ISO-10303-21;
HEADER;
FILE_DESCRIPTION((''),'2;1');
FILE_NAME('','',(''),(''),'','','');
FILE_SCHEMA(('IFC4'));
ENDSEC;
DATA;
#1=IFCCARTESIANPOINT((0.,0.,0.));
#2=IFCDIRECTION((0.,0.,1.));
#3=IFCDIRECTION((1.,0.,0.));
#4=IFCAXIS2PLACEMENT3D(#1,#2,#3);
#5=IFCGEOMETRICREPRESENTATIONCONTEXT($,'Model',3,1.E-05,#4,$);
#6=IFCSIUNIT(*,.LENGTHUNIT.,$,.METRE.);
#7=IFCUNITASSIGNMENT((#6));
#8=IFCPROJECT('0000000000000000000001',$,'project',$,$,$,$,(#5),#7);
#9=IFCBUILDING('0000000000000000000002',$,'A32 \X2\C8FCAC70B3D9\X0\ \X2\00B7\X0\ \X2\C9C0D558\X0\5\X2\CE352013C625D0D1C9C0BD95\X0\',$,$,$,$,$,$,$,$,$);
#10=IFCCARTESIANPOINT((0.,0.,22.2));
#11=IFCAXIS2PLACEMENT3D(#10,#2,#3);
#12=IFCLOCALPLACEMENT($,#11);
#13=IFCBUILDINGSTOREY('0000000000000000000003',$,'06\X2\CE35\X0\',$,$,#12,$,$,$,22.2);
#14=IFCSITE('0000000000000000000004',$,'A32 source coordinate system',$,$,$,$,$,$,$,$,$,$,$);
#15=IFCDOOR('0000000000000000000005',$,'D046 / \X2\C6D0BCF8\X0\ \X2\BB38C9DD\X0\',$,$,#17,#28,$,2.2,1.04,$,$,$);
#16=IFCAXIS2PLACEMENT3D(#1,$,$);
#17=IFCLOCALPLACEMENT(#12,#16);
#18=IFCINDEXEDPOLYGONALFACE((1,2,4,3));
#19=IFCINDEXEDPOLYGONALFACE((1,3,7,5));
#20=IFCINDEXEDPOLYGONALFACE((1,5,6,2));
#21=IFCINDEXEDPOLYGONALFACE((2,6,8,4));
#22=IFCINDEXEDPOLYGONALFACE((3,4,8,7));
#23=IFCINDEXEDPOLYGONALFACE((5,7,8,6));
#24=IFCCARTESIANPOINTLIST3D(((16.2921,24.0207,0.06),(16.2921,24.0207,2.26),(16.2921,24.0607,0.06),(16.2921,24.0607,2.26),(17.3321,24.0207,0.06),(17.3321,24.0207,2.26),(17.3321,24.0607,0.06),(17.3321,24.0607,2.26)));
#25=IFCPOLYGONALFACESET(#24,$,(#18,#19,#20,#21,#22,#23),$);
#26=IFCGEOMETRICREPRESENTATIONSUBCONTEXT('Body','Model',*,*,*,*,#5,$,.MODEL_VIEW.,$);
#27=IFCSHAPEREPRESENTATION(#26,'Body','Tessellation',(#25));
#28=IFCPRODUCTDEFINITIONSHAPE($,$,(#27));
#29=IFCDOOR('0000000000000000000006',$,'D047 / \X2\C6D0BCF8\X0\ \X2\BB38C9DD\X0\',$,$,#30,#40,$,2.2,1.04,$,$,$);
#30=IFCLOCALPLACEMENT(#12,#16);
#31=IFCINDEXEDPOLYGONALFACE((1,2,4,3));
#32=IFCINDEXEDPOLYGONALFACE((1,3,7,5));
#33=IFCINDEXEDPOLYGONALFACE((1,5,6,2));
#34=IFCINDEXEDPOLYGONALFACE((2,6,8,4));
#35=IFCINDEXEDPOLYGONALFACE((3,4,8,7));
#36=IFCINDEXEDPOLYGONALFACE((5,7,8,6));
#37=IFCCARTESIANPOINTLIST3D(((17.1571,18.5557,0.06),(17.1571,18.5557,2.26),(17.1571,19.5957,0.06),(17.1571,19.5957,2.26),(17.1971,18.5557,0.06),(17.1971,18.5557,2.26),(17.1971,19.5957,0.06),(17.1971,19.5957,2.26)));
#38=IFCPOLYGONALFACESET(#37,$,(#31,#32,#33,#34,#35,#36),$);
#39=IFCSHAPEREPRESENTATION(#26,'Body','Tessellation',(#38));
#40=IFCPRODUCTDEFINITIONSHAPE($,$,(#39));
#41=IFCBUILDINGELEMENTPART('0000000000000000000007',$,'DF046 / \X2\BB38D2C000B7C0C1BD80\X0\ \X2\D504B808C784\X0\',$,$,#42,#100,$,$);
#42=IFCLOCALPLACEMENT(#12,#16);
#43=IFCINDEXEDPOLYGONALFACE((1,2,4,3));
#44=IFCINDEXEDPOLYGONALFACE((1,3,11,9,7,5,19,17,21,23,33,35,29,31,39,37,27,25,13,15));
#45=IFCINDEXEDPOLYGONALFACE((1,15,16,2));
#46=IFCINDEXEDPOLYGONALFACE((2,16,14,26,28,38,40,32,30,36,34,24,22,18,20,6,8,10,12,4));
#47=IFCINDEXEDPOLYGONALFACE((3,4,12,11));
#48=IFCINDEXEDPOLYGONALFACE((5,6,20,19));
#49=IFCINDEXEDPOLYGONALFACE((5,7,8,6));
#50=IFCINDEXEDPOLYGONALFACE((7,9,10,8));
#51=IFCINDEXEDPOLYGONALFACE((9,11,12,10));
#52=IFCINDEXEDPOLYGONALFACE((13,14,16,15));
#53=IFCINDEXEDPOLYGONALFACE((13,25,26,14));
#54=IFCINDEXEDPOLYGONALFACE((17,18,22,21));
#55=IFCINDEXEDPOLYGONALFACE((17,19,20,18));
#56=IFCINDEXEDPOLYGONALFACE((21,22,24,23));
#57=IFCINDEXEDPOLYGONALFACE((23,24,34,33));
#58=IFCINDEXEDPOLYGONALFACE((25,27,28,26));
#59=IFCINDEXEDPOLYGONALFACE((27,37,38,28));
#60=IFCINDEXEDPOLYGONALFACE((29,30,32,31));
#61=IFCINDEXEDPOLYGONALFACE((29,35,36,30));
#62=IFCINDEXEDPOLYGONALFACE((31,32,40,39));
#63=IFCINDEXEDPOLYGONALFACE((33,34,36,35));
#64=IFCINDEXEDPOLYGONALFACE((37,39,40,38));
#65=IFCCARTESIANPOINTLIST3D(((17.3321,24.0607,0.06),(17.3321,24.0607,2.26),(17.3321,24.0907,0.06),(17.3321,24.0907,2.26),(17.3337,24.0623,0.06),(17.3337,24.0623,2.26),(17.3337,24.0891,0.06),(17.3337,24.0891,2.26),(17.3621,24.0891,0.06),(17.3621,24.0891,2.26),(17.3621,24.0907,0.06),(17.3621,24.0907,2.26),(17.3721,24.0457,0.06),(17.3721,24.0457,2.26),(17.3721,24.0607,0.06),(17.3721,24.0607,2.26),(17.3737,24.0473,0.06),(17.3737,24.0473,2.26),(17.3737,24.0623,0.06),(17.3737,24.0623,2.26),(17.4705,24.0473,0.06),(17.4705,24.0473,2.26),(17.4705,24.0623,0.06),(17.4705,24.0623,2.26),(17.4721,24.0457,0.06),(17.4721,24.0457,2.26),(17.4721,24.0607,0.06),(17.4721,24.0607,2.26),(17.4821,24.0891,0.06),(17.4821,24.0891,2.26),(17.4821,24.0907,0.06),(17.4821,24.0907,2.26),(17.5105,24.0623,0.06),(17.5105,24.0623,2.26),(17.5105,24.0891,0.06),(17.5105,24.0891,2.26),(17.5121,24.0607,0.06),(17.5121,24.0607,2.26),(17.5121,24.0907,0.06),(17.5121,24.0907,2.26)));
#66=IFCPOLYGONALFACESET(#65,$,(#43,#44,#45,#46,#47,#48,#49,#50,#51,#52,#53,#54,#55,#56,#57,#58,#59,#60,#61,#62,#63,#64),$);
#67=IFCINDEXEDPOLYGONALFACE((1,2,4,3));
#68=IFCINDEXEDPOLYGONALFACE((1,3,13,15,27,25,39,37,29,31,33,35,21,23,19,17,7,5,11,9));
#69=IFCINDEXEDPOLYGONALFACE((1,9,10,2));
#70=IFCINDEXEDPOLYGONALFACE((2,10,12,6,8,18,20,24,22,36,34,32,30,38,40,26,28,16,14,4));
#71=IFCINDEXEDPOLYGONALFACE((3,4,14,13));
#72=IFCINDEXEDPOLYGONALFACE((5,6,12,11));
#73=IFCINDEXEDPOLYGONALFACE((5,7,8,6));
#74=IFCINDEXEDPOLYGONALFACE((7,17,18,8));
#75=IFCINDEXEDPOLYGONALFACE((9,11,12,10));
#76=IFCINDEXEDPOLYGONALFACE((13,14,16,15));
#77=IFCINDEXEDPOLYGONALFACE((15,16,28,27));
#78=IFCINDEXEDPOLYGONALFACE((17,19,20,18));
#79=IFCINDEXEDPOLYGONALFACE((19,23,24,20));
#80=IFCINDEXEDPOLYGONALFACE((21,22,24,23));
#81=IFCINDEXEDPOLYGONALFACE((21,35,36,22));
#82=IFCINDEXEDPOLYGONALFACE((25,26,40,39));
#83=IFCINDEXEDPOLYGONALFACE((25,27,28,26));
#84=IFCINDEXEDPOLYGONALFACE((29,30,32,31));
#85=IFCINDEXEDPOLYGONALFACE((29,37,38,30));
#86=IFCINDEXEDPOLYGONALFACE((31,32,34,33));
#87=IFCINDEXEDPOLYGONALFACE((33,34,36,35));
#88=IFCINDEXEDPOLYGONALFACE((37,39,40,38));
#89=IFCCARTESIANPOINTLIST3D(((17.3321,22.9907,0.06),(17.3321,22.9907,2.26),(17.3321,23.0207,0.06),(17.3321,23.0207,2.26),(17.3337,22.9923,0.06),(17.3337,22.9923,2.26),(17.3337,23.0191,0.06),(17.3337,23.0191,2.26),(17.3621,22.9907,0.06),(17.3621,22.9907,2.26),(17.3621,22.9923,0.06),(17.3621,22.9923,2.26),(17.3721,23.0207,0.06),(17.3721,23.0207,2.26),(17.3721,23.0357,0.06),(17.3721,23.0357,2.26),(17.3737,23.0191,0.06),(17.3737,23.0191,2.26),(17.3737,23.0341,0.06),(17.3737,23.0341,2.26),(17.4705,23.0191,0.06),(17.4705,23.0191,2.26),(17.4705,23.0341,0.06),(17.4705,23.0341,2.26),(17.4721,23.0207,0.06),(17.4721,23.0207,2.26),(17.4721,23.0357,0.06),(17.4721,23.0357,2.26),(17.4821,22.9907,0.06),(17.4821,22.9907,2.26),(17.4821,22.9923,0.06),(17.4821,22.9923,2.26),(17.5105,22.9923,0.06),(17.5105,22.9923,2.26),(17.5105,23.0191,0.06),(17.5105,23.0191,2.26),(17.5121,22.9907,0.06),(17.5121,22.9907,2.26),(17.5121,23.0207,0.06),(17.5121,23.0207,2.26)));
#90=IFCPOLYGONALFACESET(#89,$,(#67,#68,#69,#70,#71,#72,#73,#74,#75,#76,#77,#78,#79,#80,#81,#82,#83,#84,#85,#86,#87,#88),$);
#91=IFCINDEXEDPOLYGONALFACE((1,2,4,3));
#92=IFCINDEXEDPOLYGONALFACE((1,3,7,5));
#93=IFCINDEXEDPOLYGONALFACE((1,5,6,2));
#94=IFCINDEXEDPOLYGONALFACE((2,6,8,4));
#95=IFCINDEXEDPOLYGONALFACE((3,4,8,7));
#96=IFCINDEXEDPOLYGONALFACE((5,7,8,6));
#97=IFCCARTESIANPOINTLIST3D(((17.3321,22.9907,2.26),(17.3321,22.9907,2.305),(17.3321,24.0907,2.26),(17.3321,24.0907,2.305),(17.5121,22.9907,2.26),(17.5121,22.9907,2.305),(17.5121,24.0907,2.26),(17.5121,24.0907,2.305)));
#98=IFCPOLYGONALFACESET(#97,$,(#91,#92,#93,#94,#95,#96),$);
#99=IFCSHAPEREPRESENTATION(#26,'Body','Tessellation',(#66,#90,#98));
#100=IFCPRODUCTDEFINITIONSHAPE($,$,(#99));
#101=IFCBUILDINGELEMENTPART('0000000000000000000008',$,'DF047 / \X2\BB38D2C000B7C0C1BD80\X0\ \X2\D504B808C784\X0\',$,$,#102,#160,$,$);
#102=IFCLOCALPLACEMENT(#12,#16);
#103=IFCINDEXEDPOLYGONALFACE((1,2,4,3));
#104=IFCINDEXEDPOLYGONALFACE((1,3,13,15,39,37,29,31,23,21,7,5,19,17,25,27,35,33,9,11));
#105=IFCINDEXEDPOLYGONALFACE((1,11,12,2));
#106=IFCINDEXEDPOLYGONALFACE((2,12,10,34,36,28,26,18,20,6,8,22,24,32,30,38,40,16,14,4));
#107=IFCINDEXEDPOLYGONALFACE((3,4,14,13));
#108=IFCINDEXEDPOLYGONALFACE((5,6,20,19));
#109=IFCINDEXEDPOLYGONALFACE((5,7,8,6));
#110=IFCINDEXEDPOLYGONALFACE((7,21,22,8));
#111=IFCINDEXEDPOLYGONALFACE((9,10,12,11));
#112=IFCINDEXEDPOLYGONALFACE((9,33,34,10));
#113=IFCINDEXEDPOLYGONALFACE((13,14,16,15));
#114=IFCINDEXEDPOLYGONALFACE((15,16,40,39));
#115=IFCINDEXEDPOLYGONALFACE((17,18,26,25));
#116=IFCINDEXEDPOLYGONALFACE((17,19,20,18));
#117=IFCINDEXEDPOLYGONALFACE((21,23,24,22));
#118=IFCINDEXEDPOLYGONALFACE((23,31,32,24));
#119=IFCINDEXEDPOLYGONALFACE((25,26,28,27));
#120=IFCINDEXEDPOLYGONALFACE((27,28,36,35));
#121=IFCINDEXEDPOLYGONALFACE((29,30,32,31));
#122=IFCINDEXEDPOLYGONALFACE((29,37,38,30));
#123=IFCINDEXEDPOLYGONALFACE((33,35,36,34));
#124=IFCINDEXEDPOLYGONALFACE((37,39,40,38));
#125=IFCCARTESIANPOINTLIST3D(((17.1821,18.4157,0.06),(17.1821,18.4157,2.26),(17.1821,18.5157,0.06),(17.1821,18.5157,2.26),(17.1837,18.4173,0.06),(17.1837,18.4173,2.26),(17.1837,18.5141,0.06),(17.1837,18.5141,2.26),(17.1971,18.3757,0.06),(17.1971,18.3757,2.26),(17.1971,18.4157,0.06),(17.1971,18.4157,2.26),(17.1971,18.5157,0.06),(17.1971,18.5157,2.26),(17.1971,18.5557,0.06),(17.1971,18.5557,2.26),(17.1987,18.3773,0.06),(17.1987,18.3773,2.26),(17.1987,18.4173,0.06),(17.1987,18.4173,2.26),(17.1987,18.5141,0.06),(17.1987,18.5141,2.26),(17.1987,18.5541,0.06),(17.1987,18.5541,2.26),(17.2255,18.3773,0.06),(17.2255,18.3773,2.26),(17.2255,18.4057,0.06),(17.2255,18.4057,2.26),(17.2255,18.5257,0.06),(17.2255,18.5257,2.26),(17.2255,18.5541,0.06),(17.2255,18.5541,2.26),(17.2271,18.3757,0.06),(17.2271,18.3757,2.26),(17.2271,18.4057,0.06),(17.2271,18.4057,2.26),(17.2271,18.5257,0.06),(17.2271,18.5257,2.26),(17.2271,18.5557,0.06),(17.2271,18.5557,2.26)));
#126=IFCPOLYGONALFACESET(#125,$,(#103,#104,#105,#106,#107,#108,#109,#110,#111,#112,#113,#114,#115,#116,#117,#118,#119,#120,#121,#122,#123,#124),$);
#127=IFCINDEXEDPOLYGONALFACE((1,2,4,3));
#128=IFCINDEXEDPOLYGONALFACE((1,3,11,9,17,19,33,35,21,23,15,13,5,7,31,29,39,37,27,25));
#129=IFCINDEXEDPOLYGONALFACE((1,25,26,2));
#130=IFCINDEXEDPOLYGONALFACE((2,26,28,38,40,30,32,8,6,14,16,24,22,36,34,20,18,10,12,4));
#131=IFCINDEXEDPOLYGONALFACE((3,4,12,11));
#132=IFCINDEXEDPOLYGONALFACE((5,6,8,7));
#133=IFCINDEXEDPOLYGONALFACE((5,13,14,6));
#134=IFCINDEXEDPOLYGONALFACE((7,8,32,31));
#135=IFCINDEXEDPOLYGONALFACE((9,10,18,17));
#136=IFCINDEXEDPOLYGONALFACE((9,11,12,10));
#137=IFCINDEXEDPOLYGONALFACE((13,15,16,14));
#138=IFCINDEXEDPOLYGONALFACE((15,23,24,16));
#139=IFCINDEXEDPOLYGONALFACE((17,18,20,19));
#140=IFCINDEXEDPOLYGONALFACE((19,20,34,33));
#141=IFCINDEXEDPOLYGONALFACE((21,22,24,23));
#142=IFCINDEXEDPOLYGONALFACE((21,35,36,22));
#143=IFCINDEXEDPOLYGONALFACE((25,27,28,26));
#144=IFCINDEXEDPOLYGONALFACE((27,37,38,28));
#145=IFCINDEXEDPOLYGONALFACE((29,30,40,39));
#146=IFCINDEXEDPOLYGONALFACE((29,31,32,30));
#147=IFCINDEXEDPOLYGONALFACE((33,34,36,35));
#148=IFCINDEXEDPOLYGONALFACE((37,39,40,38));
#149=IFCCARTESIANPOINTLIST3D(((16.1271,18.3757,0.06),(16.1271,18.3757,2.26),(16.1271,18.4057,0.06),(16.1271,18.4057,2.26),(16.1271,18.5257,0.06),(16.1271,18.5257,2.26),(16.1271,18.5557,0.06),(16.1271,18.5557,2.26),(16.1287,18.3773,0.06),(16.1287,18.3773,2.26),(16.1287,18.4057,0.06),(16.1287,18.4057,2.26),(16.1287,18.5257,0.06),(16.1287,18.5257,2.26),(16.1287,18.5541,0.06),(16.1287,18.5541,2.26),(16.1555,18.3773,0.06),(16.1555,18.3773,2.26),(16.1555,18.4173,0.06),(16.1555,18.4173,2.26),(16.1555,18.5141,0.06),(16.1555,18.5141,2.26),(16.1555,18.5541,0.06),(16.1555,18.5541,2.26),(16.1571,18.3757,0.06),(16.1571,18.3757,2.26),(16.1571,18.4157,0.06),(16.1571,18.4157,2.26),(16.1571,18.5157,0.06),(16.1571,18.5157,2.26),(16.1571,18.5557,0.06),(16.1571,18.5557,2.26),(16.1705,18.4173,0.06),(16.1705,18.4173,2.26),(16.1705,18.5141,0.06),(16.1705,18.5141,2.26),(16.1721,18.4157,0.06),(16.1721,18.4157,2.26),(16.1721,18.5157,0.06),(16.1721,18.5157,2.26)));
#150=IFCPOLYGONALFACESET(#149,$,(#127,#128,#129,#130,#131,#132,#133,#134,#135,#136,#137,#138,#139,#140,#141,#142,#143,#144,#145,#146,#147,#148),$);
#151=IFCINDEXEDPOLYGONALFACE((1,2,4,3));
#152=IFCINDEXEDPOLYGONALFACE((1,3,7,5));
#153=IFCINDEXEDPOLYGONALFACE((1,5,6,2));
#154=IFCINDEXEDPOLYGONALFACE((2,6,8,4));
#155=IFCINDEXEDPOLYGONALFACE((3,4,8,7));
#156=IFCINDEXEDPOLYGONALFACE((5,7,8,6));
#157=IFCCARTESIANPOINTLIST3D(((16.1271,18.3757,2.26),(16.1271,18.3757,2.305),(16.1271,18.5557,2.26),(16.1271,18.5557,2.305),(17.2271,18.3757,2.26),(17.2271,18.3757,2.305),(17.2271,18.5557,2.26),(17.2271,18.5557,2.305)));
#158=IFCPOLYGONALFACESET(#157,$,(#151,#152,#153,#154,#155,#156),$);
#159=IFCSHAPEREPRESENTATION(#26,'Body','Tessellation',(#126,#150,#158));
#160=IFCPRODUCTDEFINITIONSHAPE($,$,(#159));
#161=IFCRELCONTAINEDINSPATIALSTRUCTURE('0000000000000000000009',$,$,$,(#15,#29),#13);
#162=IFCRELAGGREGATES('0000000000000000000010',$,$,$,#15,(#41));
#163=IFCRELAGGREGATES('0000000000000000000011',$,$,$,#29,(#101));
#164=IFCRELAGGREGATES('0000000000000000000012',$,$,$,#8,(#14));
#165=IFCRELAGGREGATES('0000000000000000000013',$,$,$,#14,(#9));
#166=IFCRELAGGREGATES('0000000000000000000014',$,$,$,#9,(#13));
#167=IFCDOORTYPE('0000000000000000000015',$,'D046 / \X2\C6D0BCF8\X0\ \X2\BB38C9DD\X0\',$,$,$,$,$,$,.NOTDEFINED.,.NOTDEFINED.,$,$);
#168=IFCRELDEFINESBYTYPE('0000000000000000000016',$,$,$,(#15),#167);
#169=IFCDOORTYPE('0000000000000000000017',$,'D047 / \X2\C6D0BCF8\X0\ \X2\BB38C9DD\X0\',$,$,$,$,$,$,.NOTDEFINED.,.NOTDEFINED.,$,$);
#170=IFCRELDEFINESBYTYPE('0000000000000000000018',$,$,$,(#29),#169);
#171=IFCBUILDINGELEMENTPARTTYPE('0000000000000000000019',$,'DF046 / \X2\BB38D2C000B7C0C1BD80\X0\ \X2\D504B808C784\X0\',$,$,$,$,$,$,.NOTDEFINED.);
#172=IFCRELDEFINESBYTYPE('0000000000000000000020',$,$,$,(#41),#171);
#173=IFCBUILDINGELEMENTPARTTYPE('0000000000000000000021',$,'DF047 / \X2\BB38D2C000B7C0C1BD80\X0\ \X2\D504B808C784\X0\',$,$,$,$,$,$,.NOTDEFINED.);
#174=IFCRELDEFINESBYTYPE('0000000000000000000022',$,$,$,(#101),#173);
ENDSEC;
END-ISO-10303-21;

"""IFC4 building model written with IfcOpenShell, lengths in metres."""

from ifc_helpers import new_model, si_unit, frame, origin, origin_with_axes, place, context, subcontext, project, spatial, polyline, outline, extrude, source, transform, mapped, type_object, type_shapes, element, aggregate, save


model = new_model("IFC4")

# Units and contexts
model_context = context("Model", 3, precision=1e-05, world=origin_with_axes())
body_context = subcontext(model_context, "Body", "Model", "MODEL_VIEW")
ifc_project = project(units=[si_unit("LENGTHUNIT", "METRE")], contexts=[model_context])

# Site, building, storey
storey_placement = place(None, frame((0.0, 0.0, 22.2), z_axis=(0.0, 0.0, 1.0), x_axis=(1.0, 0.0, 0.0)))
site = spatial("IfcSite", under=ifc_project, Name="A32 source coordinate system")
building = spatial("IfcBuilding", under=site, Name="A32 주거동 · 지하5층–옥탑지붕")
storey = spatial("IfcBuildingStorey", under=building, at=storey_placement, Name="06층", Elevation=22.2)

# Doors
door_type_1 = type_object("IfcDoorType", Name="D046 / 원본 문짝", OperationType="NOTDEFINED", PredefinedType="NOTDEFINED")
shared_shape_1 = source(origin(), body_context, "Body", "SweptSolid", [
    extrude(outline(polyline([(17.3321, 24.0607), (17.3321, 24.0207), (16.2921, 24.0207), (16.2921, 24.0607), (17.3321, 24.0607)])), frame((0.0, 0.0, 0.06)), (0.0, 0.0, 1.0), 2.2),
])
type_shapes(door_type_1, [shared_shape_1])
door_1_placement = place(storey_placement, origin_with_axes())
door_1 = element("IfcDoor", 1, at=door_1_placement, inside=storey, type_object=door_type_1, Name="D046 / 원본 문짝", OverallHeight=2.2, OverallWidth=1.04, context=body_context, shape_type="MappedRepresentation", body=[
    mapped(shared_shape_1, transform((0.0, 0.0, 0.0), scale=1.0)),
])
door_type_2 = type_object("IfcDoorType", Name="D047 / 원본 문짝", OperationType="NOTDEFINED", PredefinedType="NOTDEFINED")
shared_shape_2 = source(origin(), body_context, "Body", "SweptSolid", [
    extrude(outline(polyline([(17.1971, 18.5557), (17.1571, 18.5557), (17.1571, 19.5957), (17.1971, 19.5957), (17.1971, 18.5557)])), frame((0.0, 0.0, 0.06)), (0.0, 0.0, 1.0), 2.2),
])
type_shapes(door_type_2, [shared_shape_2])
door_2_placement = place(storey_placement, origin_with_axes())
door_2 = element("IfcDoor", 2, at=door_2_placement, inside=storey, type_object=door_type_2, Name="D047 / 원본 문짝", OverallHeight=2.2, OverallWidth=1.04, context=body_context, shape_type="MappedRepresentation", body=[
    mapped(shared_shape_2, transform((0.0, 0.0, 0.0), scale=1.0)),
])

# Building element parts
building_element_part_type_1 = type_object("IfcBuildingElementPartType", Name="DF046 / 문틀·상부 프레임", PredefinedType="NOTDEFINED")
shared_shape_3 = source(origin(), body_context, "Body", "SweptSolid", [
    extrude(outline(polyline([(17.3337, 24.0891), (17.3337, 24.0623), (17.3737, 24.0623), (17.3737, 24.0473), (17.4705, 24.0473), (17.4705, 24.0623), (17.5105, 24.0623), (17.5105, 24.0891), (17.4821, 24.0891), (17.4821, 24.0907), (17.5121, 24.0907), (17.5121, 24.0607), (17.4721, 24.0607), (17.4721, 24.0457), (17.3721, 24.0457), (17.3721, 24.0607), (17.3321, 24.0607), (17.3321, 24.0907), (17.3621, 24.0907), (17.3621, 24.0891), (17.3337, 24.0891)])), frame((0.0, 0.0, 0.06)), (0.0, 0.0, 1.0), 2.2),
    extrude(outline(polyline([(17.3621, 22.9907), (17.3321, 22.9907), (17.3321, 23.0207), (17.3721, 23.0207), (17.3721, 23.0357), (17.4721, 23.0357), (17.4721, 23.0207), (17.5121, 23.0207), (17.5121, 22.9907), (17.4821, 22.9907), (17.4821, 22.9923), (17.5105, 22.9923), (17.5105, 23.0191), (17.4705, 23.0191), (17.4705, 23.0341), (17.3737, 23.0341), (17.3737, 23.0191), (17.3337, 23.0191), (17.3337, 22.9923), (17.3621, 22.9923), (17.3621, 22.9907)])), frame((0.0, 0.0, 0.06)), (0.0, 0.0, 1.0), 2.2),
    extrude(outline(polyline([(17.3321, 22.9907), (17.3321, 24.0907), (17.5121, 24.0907), (17.5121, 22.9907), (17.3321, 22.9907)])), frame((0.0, 0.0, 2.26)), (0.0, 0.0, 1.0), 0.045),
])
type_shapes(building_element_part_type_1, [shared_shape_3])
building_element_part_1_placement = place(door_1_placement, origin_with_axes())
building_element_part_1 = element("IfcBuildingElementPart", 3, at=building_element_part_1_placement, type_object=building_element_part_type_1, Name="DF046 / 문틀·상부 프레임", context=body_context, shape_type="MappedRepresentation", body=[
    mapped(shared_shape_3, transform((0.0, 0.0, 0.0), scale=1.0)),
])
aggregate(door_1, [building_element_part_1])
building_element_part_type_2 = type_object("IfcBuildingElementPartType", Name="DF047 / 문틀·상부 프레임", PredefinedType="NOTDEFINED")
shared_shape_4 = source(origin(), body_context, "Body", "SweptSolid", [
    extrude(outline(polyline([(17.2255, 18.5541), (17.1987, 18.5541), (17.1987, 18.5141), (17.1837, 18.5141), (17.1837, 18.4173), (17.1987, 18.4173), (17.1987, 18.3773), (17.2255, 18.3773), (17.2255, 18.4057), (17.2271, 18.4057), (17.2271, 18.3757), (17.1971, 18.3757), (17.1971, 18.4157), (17.1821, 18.4157), (17.1821, 18.5157), (17.1971, 18.5157), (17.1971, 18.5557), (17.2271, 18.5557), (17.2271, 18.5257), (17.2255, 18.5257), (17.2255, 18.5541)])), frame((0.0, 0.0, 0.06)), (0.0, 0.0, 1.0), 2.2),
    extrude(outline(polyline([(16.1271, 18.5257), (16.1271, 18.5557), (16.1571, 18.5557), (16.1571, 18.5157), (16.1721, 18.5157), (16.1721, 18.4157), (16.1571, 18.4157), (16.1571, 18.3757), (16.1271, 18.3757), (16.1271, 18.4057), (16.1287, 18.4057), (16.1287, 18.3773), (16.1555, 18.3773), (16.1555, 18.4173), (16.1705, 18.4173), (16.1705, 18.5141), (16.1555, 18.5141), (16.1555, 18.5541), (16.1287, 18.5541), (16.1287, 18.5257), (16.1271, 18.5257)])), frame((0.0, 0.0, 0.06)), (0.0, 0.0, 1.0), 2.2),
    extrude(outline(polyline([(16.1271, 18.3757), (16.1271, 18.5557), (17.2271, 18.5557), (17.2271, 18.3757), (16.1271, 18.3757)])), frame((0.0, 0.0, 2.26)), (0.0, 0.0, 1.0), 0.045),
])
type_shapes(building_element_part_type_2, [shared_shape_4])
building_element_part_2_placement = place(door_2_placement, origin_with_axes())
building_element_part_2 = element("IfcBuildingElementPart", 4, at=building_element_part_2_placement, type_object=building_element_part_type_2, Name="DF047 / 문틀·상부 프레임", context=body_context, shape_type="MappedRepresentation", body=[
    mapped(shared_shape_4, transform((0.0, 0.0, 0.0), scale=1.0)),
])
aggregate(door_2, [building_element_part_2])

save(model, "model.ifc")
